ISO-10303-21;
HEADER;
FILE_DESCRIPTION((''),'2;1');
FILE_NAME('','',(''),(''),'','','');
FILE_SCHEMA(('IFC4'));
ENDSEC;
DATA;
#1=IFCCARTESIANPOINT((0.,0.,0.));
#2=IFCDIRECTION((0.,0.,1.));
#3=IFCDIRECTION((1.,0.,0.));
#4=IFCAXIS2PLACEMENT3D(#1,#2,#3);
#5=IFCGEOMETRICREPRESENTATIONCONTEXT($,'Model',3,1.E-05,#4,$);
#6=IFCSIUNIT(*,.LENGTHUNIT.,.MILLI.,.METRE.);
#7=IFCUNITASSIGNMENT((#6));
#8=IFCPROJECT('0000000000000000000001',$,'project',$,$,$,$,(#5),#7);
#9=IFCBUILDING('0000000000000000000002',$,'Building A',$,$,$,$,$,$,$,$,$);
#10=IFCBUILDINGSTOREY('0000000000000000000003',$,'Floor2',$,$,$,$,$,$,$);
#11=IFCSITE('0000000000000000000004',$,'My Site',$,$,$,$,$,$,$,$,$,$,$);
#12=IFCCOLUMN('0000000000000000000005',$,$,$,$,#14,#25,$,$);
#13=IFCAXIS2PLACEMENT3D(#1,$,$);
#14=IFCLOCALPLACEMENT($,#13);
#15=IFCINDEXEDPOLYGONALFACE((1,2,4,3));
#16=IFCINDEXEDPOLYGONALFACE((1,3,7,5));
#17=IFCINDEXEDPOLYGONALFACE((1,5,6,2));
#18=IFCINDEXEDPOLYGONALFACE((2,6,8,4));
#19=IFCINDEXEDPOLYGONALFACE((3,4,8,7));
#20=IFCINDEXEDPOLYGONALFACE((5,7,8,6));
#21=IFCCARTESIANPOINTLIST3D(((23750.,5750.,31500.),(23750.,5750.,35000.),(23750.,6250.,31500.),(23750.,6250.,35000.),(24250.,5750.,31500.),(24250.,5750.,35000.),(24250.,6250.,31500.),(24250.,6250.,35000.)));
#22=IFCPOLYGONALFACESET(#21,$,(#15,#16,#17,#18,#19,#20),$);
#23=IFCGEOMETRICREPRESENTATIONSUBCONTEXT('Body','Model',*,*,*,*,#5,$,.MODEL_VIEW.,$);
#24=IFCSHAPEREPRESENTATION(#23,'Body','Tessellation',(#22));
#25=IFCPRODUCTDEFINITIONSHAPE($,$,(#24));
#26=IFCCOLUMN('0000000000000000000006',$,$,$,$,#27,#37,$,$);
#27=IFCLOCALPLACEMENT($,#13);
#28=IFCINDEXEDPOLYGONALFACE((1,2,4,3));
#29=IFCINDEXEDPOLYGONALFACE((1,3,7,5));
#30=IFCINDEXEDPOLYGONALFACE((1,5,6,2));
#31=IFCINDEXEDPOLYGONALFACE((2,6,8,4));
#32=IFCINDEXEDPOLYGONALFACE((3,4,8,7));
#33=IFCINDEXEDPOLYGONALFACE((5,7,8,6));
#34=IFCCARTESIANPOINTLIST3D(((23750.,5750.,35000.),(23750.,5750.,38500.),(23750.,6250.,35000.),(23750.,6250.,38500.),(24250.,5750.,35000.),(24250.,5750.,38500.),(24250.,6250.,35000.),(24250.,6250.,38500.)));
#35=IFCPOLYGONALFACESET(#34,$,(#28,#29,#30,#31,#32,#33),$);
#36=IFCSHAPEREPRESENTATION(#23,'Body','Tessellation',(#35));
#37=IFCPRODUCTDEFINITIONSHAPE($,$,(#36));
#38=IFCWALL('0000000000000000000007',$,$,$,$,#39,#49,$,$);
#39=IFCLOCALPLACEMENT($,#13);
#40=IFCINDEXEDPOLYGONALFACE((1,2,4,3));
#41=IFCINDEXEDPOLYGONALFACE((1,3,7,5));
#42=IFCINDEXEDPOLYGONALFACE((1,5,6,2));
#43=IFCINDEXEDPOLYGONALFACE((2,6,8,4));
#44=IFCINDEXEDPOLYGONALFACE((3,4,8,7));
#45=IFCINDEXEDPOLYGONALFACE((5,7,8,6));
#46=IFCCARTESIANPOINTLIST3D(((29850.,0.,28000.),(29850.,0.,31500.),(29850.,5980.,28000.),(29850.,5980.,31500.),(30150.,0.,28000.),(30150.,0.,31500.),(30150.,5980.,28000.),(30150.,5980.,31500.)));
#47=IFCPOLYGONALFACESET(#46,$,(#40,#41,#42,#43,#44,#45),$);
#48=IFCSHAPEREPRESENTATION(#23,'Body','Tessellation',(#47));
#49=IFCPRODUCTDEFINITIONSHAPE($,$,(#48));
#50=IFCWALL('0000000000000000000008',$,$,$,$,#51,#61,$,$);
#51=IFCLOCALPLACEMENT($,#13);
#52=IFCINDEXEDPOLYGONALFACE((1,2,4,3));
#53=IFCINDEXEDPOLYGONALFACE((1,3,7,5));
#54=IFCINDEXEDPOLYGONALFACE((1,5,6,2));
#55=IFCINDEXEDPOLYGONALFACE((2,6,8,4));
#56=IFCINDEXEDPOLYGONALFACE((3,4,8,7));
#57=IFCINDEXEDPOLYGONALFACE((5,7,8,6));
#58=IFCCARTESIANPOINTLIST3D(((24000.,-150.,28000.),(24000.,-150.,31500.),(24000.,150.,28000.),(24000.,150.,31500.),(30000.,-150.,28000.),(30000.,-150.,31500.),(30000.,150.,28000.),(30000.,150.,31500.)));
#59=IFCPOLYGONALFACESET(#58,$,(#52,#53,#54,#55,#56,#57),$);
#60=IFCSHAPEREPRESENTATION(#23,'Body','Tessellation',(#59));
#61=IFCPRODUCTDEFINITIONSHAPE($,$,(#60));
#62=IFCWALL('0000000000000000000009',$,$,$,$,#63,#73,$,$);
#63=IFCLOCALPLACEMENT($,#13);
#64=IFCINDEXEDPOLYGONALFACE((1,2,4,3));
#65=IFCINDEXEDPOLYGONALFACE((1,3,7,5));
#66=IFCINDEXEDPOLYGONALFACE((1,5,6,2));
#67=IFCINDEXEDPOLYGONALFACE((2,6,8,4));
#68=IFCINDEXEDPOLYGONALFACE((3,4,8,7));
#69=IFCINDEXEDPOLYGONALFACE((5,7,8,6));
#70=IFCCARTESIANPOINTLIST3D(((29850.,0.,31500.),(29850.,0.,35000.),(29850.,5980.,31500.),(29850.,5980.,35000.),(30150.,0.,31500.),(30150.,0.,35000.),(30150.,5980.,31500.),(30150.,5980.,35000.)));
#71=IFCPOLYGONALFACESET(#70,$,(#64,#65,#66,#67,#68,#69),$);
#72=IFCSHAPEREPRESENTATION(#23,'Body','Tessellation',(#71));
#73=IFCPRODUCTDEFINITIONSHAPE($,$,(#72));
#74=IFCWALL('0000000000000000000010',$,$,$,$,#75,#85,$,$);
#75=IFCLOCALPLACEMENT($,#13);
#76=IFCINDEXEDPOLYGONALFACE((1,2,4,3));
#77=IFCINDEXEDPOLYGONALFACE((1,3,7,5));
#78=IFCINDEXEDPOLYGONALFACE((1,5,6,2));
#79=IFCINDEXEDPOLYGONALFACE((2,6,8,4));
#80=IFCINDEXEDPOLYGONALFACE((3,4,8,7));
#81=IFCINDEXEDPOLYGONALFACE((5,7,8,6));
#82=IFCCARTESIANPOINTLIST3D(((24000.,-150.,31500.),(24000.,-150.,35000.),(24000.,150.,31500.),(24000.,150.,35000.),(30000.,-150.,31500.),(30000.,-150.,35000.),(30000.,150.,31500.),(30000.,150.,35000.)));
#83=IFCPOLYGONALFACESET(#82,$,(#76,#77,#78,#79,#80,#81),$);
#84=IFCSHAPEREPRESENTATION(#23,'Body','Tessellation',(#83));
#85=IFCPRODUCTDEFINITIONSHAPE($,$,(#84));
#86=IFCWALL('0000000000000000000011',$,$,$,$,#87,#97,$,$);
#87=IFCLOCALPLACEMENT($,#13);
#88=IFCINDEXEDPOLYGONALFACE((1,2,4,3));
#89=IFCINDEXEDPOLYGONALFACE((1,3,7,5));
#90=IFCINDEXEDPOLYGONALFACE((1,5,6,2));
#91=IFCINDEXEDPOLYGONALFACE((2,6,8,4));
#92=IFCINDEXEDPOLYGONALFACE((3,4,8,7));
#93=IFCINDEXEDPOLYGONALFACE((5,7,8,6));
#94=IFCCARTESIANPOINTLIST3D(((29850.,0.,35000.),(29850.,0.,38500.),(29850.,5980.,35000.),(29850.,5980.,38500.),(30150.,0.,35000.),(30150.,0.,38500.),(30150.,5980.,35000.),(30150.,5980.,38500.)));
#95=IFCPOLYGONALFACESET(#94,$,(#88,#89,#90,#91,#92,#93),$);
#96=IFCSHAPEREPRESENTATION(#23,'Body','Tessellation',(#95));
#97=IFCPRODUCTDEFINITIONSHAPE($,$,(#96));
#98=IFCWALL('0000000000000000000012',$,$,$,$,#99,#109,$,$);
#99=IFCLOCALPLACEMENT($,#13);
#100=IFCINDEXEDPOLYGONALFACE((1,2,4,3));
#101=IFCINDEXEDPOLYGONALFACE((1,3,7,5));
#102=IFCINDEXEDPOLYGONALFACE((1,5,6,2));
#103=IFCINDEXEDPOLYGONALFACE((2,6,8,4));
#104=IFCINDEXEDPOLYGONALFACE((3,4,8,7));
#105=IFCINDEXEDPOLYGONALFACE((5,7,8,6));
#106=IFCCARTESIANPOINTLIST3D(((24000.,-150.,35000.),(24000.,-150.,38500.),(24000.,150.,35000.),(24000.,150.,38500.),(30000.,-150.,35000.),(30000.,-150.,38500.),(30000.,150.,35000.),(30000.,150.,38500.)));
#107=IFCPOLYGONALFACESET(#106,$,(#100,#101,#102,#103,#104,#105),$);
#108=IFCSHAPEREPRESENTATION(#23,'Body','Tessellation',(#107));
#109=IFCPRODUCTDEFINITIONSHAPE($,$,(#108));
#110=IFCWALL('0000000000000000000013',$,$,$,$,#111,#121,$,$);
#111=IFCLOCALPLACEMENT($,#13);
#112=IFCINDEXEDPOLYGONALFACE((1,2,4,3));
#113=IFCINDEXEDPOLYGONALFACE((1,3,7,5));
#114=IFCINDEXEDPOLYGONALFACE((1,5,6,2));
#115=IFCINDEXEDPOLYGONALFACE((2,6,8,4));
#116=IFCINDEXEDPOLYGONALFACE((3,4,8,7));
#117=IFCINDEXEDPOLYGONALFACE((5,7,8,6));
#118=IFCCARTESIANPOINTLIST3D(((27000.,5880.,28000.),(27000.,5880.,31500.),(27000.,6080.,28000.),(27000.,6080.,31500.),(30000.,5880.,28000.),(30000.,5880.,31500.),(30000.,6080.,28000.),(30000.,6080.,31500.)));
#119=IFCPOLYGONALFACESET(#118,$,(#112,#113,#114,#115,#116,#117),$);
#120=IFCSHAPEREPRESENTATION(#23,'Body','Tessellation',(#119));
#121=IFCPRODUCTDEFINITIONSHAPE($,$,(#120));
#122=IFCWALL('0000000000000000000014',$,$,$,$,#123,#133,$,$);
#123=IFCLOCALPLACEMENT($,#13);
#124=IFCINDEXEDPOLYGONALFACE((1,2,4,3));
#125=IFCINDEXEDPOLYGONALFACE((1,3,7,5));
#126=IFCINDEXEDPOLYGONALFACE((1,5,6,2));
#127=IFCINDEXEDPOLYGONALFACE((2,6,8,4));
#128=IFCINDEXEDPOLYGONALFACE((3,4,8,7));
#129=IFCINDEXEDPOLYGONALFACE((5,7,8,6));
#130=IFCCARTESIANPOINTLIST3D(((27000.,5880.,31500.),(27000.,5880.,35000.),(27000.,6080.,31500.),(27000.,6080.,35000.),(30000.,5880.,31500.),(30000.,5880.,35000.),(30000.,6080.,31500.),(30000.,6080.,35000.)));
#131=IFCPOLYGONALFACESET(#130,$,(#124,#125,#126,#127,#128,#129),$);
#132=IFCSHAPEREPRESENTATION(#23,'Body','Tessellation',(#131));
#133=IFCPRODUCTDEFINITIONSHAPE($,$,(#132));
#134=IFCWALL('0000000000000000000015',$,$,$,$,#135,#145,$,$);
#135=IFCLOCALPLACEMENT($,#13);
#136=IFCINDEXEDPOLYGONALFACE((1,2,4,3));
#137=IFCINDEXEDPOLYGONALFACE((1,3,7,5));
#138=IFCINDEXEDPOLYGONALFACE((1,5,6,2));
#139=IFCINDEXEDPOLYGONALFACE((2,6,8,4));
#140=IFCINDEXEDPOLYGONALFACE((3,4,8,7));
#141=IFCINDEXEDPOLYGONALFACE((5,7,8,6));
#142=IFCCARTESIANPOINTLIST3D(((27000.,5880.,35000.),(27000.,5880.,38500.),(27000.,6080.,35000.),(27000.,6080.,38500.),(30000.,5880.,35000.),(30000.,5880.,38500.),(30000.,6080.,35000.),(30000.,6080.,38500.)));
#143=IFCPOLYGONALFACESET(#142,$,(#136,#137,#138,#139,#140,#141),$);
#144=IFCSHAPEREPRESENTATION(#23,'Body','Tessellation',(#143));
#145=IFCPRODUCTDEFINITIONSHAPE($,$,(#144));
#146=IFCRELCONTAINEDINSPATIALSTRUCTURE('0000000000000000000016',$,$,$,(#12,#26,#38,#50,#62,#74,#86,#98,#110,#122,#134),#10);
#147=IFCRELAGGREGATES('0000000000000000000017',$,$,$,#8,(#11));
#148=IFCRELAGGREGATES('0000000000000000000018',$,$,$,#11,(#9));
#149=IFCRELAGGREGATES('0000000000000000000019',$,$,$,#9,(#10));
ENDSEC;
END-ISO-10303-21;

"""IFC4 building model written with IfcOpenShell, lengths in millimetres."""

from ifc_helpers import new_model, si_unit, frame, origin_with_axes, place, context, subcontext, project, spatial, line, indexed_curve, outline, extrude, element, save


model = new_model("IFC4")

# Units and contexts
model_context = context("Model", 3, precision=1e-05, world=origin_with_axes())
body_context = subcontext(model_context, "Body", "Model", "MODEL_VIEW")
ifc_project = project(units=[si_unit("LENGTHUNIT", "METRE", prefix="MILLI")], contexts=[model_context])

# Site, building, storey
site = spatial("IfcSite", under=ifc_project, Name="My Site")
building = spatial("IfcBuilding", under=site, Name="Building A")
storey = spatial("IfcBuildingStorey", under=building, Name="Floor2")

# Columns
for number, where, z_axis, x_axis in (
    (1, (24000.0, 6000.0, 31500.0), (0.0, 0.0, 1.0), (1.0, 0.0, 0.0)),
    (2, (24000.0, 6000.0, 35000.0), (0.0, 0.0, 1.0), (1.0, 0.0, 0.0)),
):
    element("IfcColumn", number, at=place(None, frame(where, z_axis=z_axis, x_axis=x_axis)), inside=storey, context=body_context, shape_type="SweptSolid", body=[
        extrude(outline(indexed_curve([(-250.0, -250.0), (250.0, -250.0), (250.0, 250.0), (-250.0, 250.0)], segments=[line(1, 2, 3, 4, 1)])), origin_with_axes(), (0.0, 0.0, 1.0), 3500.0),
    ])

# Walls
wall_1_placement = place(None, frame((29850.0, 5980.0, 28000.0), z_axis=(0.0, 0.0, 1.0), x_axis=(0.0, -1.0, 0.0)))
element("IfcWall", 3, at=wall_1_placement, inside=storey, context=body_context, shape_type="SweptSolid", body=[
    extrude(outline(indexed_curve([(0.0, 0.0), (0.0, 300.0), (5980.0, 300.0), (5980.0, 0.0), (0.0, 0.0)], self_intersect=False)), origin_with_axes(), (0.0, 0.0, 1.0), 3500.0),
])
wall_2_placement = place(None, frame((30000.0, 150.0, 28000.0), z_axis=(0.0, 0.0, 1.0), x_axis=(-1.0, 0.0, 0.0)))
element("IfcWall", 4, at=wall_2_placement, inside=storey, context=body_context, shape_type="SweptSolid", body=[
    extrude(outline(indexed_curve([(0.0, 0.0), (0.0, 300.0), (6000.0, 300.0), (6000.0, 0.0), (0.0, 0.0)], self_intersect=False)), origin_with_axes(), (0.0, 0.0, 1.0), 3500.0),
])
wall_3_placement = place(None, frame((29850.0, 5980.0, 31500.0), z_axis=(0.0, 0.0, 1.0), x_axis=(0.0, -1.0, 0.0)))
element("IfcWall", 5, at=wall_3_placement, inside=storey, context=body_context, shape_type="SweptSolid", body=[
    extrude(outline(indexed_curve([(0.0, 0.0), (0.0, 300.0), (5980.0, 300.0), (5980.0, 0.0), (0.0, 0.0)], self_intersect=False)), origin_with_axes(), (0.0, 0.0, 1.0), 3500.0),
])
wall_4_placement = place(None, frame((30000.0, 150.0, 31500.0), z_axis=(0.0, 0.0, 1.0), x_axis=(-1.0, 0.0, 0.0)))
element("IfcWall", 6, at=wall_4_placement, inside=storey, context=body_context, shape_type="SweptSolid", body=[
    extrude(outline(indexed_curve([(0.0, 0.0), (0.0, 300.0), (6000.0, 300.0), (6000.0, 0.0), (0.0, 0.0)], self_intersect=False)), origin_with_axes(), (0.0, 0.0, 1.0), 3500.0),
])
wall_5_placement = place(None, frame((29850.0, 5980.0, 35000.0), z_axis=(0.0, 0.0, 1.0), x_axis=(0.0, -1.0, 0.0)))
element("IfcWall", 7, at=wall_5_placement, inside=storey, context=body_context, shape_type="SweptSolid", body=[
    extrude(outline(indexed_curve([(0.0, 0.0), (0.0, 300.0), (5980.0, 300.0), (5980.0, 0.0), (0.0, 0.0)], self_intersect=False)), origin_with_axes(), (0.0, 0.0, 1.0), 3500.0),
])
wall_6_placement = place(None, frame((30000.0, 150.0, 35000.0), z_axis=(0.0, 0.0, 1.0), x_axis=(-1.0, 0.0, 0.0)))
element("IfcWall", 8, at=wall_6_placement, inside=storey, context=body_context, shape_type="SweptSolid", body=[
    extrude(outline(indexed_curve([(0.0, 0.0), (0.0, 300.0), (6000.0, 300.0), (6000.0, 0.0), (0.0, 0.0)], self_intersect=False)), origin_with_axes(), (0.0, 0.0, 1.0), 3500.0),
])
for number, where, z_axis, x_axis in (
    (9, (27000.0, 5880.0, 28000.0), (0.0, 0.0, 1.0), (1.0, 0.0, 0.0)),
    (10, (27000.0, 5880.0, 31500.0), (0.0, 0.0, 1.0), (1.0, 0.0, 0.0)),
    (11, (27000.0, 5880.0, 35000.0), (0.0, 0.0, 1.0), (1.0, 0.0, 0.0)),
):
    element("IfcWall", number, at=place(None, frame(where, z_axis=z_axis, x_axis=x_axis)), inside=storey, context=body_context, shape_type="SweptSolid", body=[
        extrude(outline(indexed_curve([(0.0, 0.0), (0.0, 200.0), (3000.0, 200.0), (3000.0, 0.0), (0.0, 0.0)], self_intersect=False)), origin_with_axes(), (0.0, 0.0, 1.0), 3500.0),
    ])

save(model, "model.ifc")
